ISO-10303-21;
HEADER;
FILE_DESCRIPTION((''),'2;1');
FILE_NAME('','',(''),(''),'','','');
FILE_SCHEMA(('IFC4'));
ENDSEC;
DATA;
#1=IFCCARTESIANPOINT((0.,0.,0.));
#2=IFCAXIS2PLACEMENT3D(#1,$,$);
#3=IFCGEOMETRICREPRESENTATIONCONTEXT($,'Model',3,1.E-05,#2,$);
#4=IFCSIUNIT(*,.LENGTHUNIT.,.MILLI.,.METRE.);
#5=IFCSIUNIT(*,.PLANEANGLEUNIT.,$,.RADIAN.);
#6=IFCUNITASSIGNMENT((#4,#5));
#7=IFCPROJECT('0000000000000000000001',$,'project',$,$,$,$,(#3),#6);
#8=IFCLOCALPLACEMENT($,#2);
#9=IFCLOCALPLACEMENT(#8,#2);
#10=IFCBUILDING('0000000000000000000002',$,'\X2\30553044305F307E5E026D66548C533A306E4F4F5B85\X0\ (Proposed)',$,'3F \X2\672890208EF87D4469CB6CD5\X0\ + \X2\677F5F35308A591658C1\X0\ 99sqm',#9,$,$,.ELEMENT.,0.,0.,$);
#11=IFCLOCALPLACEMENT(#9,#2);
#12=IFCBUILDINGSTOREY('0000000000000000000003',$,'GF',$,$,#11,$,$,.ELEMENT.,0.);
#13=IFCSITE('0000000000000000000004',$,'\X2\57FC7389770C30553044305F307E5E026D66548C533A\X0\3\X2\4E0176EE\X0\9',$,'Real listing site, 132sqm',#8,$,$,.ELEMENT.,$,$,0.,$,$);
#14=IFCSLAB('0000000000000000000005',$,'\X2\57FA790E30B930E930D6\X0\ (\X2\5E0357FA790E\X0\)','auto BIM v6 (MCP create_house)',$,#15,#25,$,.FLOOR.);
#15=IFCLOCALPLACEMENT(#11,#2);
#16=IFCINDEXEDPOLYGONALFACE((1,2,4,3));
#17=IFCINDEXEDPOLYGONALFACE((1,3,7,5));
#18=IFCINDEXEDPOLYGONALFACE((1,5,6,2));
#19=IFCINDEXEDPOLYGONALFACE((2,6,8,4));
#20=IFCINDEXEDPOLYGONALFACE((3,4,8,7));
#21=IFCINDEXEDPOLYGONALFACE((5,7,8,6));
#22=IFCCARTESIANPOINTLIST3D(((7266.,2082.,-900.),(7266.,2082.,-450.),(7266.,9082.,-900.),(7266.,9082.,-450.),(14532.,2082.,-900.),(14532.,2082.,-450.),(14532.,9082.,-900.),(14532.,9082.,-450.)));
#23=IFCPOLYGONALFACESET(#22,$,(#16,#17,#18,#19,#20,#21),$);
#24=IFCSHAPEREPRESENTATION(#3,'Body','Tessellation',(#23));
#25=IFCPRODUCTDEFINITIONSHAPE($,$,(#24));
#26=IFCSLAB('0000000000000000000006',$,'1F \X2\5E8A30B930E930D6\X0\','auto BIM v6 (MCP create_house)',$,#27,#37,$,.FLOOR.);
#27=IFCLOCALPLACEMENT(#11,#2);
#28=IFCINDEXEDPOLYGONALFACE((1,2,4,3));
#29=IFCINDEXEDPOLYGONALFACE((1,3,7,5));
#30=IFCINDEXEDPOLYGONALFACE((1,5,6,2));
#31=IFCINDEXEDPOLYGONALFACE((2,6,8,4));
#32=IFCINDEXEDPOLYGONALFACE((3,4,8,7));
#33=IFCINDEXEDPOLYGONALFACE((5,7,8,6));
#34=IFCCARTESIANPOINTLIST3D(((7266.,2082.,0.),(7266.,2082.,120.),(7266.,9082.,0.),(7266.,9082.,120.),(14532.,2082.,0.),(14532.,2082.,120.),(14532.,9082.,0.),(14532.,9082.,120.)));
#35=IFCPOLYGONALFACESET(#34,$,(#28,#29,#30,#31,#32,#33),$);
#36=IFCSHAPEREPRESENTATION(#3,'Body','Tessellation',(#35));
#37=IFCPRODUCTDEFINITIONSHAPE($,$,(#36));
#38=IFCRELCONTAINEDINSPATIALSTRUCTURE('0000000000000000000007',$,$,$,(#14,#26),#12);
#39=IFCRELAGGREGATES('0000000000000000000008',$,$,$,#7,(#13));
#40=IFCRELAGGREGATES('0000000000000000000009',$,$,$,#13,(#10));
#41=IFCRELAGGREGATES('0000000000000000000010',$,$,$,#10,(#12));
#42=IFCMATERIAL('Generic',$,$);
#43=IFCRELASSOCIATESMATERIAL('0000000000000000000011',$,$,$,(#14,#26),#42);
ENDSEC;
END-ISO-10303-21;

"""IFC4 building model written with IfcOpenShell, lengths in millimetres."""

from ifc_helpers import new_model, si_unit, frame, frame_2d, origin, place, context, project, spatial, rectangle, extrude, material, element, save


model = new_model("IFC4")

# Units and contexts
model_context = context("Model", 3, precision=1e-05, world=origin())
ifc_project = project(units=[si_unit("LENGTHUNIT", "METRE", prefix="MILLI"), si_unit("PLANEANGLEUNIT", "RADIAN")], contexts=[model_context])

# Site, building, storey
site_placement = place(None, origin())
site = spatial("IfcSite", under=ifc_project, at=site_placement, Name="埼玉県さいたま市浦和区3丁目9", ObjectType="Real listing site, 132sqm", CompositionType="ELEMENT", RefElevation=0.0)
building_placement = place(site_placement, origin())
building = spatial("IfcBuilding", under=site, at=building_placement, Name="さいたま市浦和区の住宅 (Proposed)", ObjectType="3F 木造軸組構法 + 板張り外壁 99sqm", CompositionType="ELEMENT", ElevationOfRefHeight=0.0, ElevationOfTerrain=0.0)
storey_placement = place(building_placement, origin())
storey = spatial("IfcBuildingStorey", under=building, at=storey_placement, Name="GF", CompositionType="ELEMENT", Elevation=0.0)

# Slabs
ifc_material = material(Name="Generic")
slab_1_placement = place(storey_placement, frame((3633.0, 1041.0, -450.0)))
element("IfcSlab", 1, at=slab_1_placement, inside=storey, material=ifc_material, Name="基礎スラブ (布基礎)", Description="auto BIM v6 (MCP create_house)", PredefinedType="FLOOR", context=model_context, shape_type="SweptSolid", body=[
    extrude(rectangle(XDim=7266.0, YDim=7000.0, at=frame_2d((3633.0, 3500.0))), frame((3633.0, 1041.0, -450.0)), (0.0, 0.0, 1.0), 450.0),
])
slab_2_placement = place(storey_placement, frame((3633.0, 1041.0, 0.0)))
element("IfcSlab", 2, at=slab_2_placement, inside=storey, material=ifc_material, Name="1F 床スラブ", Description="auto BIM v6 (MCP create_house)", PredefinedType="FLOOR", context=model_context, shape_type="SweptSolid", body=[
    extrude(rectangle(XDim=7266.0, YDim=7000.0, at=frame_2d((3633.0, 3500.0))), frame((3633.0, 1041.0, 0.0)), (0.0, 0.0, 1.0), 120.0),
])

save(model, "model.ifc")
